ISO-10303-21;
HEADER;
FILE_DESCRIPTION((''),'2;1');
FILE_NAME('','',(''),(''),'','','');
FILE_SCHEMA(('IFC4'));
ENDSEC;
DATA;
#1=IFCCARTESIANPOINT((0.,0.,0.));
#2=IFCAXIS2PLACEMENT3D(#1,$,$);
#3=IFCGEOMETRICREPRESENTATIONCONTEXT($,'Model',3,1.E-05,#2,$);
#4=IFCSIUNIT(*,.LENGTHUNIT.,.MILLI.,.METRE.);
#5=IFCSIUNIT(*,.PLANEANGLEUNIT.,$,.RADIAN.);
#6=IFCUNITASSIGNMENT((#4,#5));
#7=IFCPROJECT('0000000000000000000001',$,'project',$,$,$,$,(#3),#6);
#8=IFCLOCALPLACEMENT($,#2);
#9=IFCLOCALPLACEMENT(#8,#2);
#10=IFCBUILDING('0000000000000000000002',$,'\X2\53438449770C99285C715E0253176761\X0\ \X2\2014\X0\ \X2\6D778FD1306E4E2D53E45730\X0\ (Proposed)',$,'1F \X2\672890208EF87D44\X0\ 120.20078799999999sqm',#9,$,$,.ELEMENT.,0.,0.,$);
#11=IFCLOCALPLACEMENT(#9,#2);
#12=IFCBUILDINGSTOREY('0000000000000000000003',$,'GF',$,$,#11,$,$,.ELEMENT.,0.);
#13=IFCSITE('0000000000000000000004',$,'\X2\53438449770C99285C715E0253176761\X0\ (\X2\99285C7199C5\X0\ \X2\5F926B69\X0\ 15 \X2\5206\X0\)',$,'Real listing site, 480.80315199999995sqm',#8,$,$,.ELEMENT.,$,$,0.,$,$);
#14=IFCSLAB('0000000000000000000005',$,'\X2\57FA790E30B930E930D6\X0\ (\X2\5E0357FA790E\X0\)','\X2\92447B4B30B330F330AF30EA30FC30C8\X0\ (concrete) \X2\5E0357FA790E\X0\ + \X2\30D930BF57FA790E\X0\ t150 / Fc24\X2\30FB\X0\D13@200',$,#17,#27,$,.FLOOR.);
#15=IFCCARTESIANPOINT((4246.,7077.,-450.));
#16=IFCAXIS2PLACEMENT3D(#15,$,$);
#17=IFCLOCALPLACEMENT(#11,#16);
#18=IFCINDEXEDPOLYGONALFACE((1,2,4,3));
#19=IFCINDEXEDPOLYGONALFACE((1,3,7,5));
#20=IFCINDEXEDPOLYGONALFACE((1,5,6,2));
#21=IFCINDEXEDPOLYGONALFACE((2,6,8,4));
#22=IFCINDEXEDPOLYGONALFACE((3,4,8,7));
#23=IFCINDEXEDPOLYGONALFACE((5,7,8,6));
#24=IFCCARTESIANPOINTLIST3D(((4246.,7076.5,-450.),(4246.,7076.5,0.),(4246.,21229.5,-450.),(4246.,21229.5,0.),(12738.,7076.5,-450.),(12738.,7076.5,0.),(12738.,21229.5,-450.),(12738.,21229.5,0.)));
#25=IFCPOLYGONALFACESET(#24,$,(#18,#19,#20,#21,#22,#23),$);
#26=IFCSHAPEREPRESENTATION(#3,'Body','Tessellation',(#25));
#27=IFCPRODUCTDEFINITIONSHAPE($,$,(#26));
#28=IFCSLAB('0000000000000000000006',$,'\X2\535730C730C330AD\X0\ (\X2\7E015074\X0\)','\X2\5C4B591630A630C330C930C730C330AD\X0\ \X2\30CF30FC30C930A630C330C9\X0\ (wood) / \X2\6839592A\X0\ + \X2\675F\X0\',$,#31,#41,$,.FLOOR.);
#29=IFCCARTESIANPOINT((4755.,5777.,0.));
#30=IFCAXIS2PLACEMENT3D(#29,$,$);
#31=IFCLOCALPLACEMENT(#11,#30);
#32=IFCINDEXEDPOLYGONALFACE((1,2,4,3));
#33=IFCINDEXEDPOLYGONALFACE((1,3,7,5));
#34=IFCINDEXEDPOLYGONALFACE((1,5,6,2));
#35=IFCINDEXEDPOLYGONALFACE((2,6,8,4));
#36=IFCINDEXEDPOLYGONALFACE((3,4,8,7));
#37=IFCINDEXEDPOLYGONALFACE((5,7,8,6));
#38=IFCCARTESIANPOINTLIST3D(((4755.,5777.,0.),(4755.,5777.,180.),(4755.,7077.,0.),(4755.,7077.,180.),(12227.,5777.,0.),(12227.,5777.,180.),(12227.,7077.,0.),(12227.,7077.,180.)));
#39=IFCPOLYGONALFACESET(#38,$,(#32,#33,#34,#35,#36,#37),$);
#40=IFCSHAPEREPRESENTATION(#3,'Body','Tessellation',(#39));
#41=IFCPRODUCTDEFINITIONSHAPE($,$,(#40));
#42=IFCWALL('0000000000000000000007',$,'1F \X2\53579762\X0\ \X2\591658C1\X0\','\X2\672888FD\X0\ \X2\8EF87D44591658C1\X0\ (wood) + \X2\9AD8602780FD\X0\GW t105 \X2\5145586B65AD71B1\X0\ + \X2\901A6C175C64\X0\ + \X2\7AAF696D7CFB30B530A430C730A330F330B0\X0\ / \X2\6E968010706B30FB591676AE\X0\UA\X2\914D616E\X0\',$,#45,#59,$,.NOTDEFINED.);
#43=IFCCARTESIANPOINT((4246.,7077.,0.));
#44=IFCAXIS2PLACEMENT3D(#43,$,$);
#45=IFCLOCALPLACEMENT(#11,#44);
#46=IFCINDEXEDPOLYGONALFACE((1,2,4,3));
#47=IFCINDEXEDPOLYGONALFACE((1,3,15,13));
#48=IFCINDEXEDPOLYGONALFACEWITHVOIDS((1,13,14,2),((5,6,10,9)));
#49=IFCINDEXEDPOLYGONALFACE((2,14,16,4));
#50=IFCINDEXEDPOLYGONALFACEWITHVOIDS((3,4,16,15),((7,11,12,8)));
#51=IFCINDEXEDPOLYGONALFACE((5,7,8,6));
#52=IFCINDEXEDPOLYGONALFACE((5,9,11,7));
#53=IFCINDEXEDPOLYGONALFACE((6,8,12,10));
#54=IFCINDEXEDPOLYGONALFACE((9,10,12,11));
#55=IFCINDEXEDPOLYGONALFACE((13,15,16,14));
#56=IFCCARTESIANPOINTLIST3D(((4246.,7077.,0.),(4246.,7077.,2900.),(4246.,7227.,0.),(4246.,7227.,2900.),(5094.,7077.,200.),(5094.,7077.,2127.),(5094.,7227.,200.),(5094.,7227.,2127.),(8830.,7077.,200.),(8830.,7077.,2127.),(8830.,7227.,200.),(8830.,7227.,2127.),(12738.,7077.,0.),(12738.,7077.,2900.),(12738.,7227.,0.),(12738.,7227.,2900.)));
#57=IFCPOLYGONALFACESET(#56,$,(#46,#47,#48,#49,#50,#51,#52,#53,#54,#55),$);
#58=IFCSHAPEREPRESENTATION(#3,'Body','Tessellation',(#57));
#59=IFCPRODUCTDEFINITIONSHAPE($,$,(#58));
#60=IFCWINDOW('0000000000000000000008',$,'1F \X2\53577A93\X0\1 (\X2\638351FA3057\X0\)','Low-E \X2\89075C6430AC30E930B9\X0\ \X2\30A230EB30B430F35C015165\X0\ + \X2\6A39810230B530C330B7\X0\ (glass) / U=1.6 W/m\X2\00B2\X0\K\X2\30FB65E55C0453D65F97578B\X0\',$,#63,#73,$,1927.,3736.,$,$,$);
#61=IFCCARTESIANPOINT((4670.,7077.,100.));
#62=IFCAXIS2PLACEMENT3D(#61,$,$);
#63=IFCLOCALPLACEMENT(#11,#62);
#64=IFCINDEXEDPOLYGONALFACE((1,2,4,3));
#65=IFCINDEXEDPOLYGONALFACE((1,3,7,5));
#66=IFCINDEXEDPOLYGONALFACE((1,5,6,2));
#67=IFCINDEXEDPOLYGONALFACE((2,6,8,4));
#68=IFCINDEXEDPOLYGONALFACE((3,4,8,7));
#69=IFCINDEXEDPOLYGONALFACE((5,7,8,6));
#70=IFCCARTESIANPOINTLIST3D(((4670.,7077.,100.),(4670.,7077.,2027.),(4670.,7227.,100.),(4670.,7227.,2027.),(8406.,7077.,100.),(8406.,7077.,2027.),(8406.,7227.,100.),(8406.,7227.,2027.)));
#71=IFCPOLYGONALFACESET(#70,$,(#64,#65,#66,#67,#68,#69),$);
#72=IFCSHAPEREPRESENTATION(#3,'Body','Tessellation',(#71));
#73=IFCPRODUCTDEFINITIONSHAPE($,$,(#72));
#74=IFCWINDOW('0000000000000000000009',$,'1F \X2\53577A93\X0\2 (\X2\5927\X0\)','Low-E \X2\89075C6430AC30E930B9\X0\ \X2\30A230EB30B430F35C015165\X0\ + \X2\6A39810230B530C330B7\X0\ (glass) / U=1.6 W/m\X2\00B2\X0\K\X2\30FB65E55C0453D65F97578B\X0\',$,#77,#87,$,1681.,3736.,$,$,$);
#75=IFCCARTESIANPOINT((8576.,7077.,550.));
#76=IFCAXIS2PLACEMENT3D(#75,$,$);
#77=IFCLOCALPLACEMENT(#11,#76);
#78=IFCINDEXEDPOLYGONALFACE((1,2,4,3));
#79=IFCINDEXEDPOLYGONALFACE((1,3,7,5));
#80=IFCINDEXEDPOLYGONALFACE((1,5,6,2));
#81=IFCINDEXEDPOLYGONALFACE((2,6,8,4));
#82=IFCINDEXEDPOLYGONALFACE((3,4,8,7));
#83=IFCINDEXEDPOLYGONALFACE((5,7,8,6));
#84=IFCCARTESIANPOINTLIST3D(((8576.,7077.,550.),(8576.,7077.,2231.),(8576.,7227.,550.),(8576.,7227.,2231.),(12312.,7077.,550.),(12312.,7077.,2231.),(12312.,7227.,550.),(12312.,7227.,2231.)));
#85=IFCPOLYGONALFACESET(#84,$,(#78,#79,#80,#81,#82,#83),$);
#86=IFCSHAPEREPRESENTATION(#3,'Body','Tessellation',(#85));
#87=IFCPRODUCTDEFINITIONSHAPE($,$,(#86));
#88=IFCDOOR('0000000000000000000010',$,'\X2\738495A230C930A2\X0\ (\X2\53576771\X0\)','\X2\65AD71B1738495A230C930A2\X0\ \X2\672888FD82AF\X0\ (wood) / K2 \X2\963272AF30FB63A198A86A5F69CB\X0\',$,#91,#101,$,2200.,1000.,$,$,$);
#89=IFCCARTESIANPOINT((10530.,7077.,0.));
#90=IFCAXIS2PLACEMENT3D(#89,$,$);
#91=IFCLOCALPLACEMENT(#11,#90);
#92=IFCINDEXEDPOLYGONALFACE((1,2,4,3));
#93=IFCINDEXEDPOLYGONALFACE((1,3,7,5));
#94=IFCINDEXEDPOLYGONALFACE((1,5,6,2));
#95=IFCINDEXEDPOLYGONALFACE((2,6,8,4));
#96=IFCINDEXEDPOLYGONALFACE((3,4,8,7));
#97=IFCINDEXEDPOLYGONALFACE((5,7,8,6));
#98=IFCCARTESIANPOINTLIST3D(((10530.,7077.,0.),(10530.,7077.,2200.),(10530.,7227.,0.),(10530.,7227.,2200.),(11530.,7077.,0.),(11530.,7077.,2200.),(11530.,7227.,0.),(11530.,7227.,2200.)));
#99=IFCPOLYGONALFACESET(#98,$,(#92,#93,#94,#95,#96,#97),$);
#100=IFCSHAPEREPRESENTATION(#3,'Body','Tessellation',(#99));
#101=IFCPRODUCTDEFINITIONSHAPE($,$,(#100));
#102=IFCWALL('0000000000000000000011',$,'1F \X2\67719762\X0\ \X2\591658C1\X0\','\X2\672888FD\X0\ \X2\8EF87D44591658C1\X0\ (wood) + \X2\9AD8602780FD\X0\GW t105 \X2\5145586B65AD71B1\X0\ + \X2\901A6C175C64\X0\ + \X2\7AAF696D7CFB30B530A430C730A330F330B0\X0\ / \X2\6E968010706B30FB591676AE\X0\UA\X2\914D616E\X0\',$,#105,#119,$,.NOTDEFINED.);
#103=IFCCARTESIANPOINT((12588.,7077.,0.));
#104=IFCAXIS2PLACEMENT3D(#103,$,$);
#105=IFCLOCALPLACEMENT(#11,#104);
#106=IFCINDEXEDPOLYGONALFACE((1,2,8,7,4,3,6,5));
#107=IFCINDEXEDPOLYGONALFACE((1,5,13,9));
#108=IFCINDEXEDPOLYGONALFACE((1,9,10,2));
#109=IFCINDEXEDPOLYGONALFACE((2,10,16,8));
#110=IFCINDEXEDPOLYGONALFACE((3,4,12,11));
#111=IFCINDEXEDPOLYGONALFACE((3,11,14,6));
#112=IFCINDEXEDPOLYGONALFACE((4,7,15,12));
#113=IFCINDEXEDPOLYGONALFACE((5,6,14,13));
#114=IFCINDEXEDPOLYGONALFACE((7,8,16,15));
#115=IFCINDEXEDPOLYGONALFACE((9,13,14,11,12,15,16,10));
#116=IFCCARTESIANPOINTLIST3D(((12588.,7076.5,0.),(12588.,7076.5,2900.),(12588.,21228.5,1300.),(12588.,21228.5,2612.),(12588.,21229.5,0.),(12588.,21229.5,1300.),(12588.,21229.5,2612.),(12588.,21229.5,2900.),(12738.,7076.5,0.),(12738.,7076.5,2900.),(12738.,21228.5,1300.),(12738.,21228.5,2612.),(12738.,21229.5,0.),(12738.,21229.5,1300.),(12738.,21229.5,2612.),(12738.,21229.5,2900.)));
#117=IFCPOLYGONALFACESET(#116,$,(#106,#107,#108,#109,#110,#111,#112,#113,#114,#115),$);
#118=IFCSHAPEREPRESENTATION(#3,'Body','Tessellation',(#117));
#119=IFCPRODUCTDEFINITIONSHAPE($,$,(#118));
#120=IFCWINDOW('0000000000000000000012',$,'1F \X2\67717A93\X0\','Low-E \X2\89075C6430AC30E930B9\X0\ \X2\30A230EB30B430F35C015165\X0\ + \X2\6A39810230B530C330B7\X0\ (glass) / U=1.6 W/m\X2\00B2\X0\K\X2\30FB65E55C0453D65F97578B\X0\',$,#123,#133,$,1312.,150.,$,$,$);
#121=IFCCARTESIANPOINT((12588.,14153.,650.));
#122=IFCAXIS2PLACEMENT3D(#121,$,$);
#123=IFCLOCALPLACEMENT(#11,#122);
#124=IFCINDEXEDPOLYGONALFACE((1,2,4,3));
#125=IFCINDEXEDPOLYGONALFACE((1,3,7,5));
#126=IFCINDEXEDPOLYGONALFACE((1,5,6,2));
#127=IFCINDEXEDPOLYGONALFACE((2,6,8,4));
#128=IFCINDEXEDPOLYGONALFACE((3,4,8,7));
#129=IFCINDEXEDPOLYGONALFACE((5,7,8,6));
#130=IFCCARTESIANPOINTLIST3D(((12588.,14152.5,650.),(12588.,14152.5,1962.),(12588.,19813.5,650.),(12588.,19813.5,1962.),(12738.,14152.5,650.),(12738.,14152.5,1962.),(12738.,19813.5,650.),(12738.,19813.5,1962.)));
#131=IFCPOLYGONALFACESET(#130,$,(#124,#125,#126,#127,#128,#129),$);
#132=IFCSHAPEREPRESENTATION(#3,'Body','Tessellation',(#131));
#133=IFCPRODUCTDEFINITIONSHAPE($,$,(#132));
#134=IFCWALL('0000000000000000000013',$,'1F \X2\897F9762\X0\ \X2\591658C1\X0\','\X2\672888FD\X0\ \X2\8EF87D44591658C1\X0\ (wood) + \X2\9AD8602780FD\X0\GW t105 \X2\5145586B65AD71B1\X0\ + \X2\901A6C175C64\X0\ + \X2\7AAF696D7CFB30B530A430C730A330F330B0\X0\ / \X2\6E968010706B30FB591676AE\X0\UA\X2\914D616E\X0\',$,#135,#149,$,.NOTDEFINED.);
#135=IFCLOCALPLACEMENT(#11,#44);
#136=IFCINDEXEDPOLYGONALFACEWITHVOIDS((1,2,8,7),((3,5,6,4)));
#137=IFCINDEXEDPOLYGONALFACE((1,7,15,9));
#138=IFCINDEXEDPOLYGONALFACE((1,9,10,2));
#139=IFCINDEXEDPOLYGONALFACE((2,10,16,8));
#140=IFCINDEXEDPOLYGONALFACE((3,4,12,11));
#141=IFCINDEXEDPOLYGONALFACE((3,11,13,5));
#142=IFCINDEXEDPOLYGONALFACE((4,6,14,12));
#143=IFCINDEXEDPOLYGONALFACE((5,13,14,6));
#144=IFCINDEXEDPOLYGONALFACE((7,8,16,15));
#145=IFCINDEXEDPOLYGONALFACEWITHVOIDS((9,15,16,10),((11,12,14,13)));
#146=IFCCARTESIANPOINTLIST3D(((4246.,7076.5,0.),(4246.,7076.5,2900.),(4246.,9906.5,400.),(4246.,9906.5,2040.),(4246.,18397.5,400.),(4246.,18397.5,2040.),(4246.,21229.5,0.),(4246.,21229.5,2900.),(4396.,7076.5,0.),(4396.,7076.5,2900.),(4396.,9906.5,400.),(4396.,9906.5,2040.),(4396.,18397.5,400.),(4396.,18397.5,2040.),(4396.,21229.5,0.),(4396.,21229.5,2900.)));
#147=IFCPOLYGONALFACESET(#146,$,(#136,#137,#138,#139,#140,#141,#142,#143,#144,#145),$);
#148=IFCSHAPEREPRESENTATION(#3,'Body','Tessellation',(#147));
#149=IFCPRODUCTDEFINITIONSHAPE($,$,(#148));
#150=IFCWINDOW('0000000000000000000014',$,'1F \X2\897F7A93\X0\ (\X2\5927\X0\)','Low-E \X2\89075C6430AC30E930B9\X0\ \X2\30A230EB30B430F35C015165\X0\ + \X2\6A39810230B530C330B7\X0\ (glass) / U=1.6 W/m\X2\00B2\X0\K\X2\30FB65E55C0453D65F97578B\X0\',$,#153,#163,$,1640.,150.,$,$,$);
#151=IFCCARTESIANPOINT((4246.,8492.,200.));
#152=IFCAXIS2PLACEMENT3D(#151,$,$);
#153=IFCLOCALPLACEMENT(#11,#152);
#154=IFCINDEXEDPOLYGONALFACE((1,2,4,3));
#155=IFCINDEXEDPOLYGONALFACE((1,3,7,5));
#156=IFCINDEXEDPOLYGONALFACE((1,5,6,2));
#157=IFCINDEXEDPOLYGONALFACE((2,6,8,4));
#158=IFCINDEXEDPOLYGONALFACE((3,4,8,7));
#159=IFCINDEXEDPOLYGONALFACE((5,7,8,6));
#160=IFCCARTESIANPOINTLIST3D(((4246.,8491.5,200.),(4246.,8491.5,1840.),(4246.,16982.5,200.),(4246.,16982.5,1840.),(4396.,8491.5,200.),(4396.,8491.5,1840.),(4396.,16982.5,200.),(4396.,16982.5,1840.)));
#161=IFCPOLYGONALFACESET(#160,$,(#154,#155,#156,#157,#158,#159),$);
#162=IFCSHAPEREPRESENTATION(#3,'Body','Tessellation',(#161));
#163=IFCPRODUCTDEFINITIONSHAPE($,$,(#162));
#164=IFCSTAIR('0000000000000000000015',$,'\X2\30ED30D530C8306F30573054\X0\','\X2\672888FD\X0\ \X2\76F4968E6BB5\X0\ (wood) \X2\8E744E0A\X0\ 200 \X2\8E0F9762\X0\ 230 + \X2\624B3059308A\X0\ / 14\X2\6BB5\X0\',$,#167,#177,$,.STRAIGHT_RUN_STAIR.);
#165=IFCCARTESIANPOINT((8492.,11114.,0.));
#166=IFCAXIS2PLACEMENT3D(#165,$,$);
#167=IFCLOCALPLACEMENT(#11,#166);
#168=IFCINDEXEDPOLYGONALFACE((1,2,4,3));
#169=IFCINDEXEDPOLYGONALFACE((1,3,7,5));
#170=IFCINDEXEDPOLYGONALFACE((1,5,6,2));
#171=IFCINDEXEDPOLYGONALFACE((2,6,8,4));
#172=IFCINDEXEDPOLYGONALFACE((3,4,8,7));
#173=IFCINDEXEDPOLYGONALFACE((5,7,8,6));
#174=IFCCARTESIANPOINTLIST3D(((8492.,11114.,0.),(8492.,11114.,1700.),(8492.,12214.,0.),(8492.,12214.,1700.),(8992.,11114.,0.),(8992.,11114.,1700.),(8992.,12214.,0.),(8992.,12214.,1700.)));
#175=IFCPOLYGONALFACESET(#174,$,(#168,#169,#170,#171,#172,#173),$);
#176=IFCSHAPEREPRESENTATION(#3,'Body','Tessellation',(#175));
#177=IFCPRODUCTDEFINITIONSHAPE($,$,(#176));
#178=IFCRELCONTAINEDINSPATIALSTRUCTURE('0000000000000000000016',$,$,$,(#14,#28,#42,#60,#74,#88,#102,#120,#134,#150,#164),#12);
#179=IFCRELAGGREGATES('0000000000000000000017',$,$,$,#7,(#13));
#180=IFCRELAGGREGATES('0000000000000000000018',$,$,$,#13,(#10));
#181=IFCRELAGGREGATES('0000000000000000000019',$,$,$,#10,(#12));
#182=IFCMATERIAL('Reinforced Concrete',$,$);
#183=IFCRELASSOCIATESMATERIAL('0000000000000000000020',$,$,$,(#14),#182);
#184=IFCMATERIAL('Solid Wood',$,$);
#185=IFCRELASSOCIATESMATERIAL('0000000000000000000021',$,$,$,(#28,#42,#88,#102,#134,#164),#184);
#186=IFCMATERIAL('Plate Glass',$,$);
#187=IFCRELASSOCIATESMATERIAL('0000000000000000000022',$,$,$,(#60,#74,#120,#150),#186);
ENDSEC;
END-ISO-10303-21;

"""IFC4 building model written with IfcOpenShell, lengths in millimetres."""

from ifc_helpers import new_model, si_unit, frame, frame_2d, origin, place, context, project, spatial, rectangle, extrude, material, element, fill, save


model = new_model("IFC4")

# Units and contexts
model_context = context("Model", 3, precision=1e-05, world=origin())
ifc_project = project(units=[si_unit("LENGTHUNIT", "METRE", prefix="MILLI"), si_unit("PLANEANGLEUNIT", "RADIAN")], contexts=[model_context])

# Site, building, storey
site_placement = place(None, origin())
site = spatial("IfcSite", under=ifc_project, at=site_placement, Name="千葉県館山市北条 (館山駅 徒歩 15 分)", ObjectType="Real listing site, 480.80315199999995sqm", CompositionType="ELEMENT", RefElevation=0.0)
building_placement = place(site_placement, origin())
building = spatial("IfcBuilding", under=site, at=building_placement, Name="千葉県館山市北条 — 海近の中古地 (Proposed)", ObjectType="1F 木造軸組 120.20078799999999sqm", CompositionType="ELEMENT", ElevationOfRefHeight=0.0, ElevationOfTerrain=0.0)
storey_placement = place(building_placement, origin())
storey = spatial("IfcBuildingStorey", under=building, at=storey_placement, Name="GF", CompositionType="ELEMENT", Elevation=0.0)

# Slabs
ifc_material_1 = material(Name="Reinforced Concrete")
slab_1_placement = place(storey_placement, frame((4246.0, 7077.0, -450.0)))
element("IfcSlab", 1, at=slab_1_placement, inside=storey, material=ifc_material_1, Name="基礎スラブ (布基礎)", Description="鉄筋コンクリート (concrete) 布基礎 + ベタ基礎 t150 / Fc24・D13@200", PredefinedType="FLOOR", context=model_context, shape_type="SweptSolid", body=[
    extrude(rectangle(XDim=8492.0, YDim=14153.0, at=frame_2d((4246.0, 7076.0))), frame((4246.0, 7077.0, -450.0)), (0.0, 0.0, 1.0), 450.0),
])
ifc_material_2 = material(Name="Solid Wood")
slab_2_placement = place(storey_placement, frame((4755.0, 5777.0, 0.0)))
element("IfcSlab", 2, at=slab_2_placement, inside=storey, material=ifc_material_2, Name="南デッキ (縁側)", Description="屋外ウッドデッキ ハードウッド (wood) / 根太 + 束", PredefinedType="FLOOR", context=model_context, shape_type="SweptSolid", body=[
    extrude(rectangle(XDim=7472.0, YDim=1300.0, at=frame_2d((3736.0, 650.0))), frame((4755.0, 5777.0, 0.0)), (0.0, 0.0, 1.0), 180.0),
])

# Wall, openings, windows, door
wall_1_placement = place(storey_placement, frame((4246.0, 7077.0, 0.0)))
wall_1 = element("IfcWall", 3, at=wall_1_placement, inside=storey, material=ifc_material_2, Name="1F 南面 外壁", Description="木製 軸組外壁 (wood) + 高性能GW t105 充填断熱 + 通気層 + 窯業系サイディング / 準耐火・外皮UA配慮", PredefinedType="NOTDEFINED", context=model_context, shape_type="SweptSolid", body=[
    extrude(rectangle(XDim=8492.0, YDim=150.0, at=frame_2d((4246.0, 75.0))), frame((4246.0, 7077.0, 0.0)), (0.0, 0.0, 1.0), 2900.0),
])
opening_1_placement = place(storey_placement, frame((4670.0, 7077.0, 100.0)))
opening_1 = element("IfcOpeningElement", 4, at=opening_1_placement, cuts=wall_1, PredefinedType="NOTDEFINED", context=model_context, shape_type="SweptSolid", body=[
    extrude(rectangle(XDim=3736.0, YDim=150.0, at=frame_2d((1868.0, 75.0))), frame((4670.0, 7077.0, 100.0)), (0.0, 0.0, 1.0), 1927.0),
])
opening_2_placement = place(storey_placement, frame((8576.0, 7077.0, 550.0)))
opening_2 = element("IfcOpeningElement", 5, at=opening_2_placement, cuts=wall_1, PredefinedType="NOTDEFINED", context=model_context, shape_type="SweptSolid", body=[
    extrude(rectangle(XDim=3736.0, YDim=150.0, at=frame_2d((1868.0, 75.0))), frame((8576.0, 7077.0, 550.0)), (0.0, 0.0, 1.0), 1681.0),
])
opening_3_placement = place(storey_placement, frame((10530.0, 7077.0, 0.0)))
opening_3 = element("IfcOpeningElement", 6, at=opening_3_placement, cuts=wall_1, PredefinedType="NOTDEFINED", context=model_context, shape_type="SweptSolid", body=[
    extrude(rectangle(XDim=1000.0, YDim=150.0, at=frame_2d((500.0, 75.0))), frame((10530.0, 7077.0, 0.0)), (0.0, 0.0, 1.0), 2200.0),
])
ifc_material_3 = material(Name="Plate Glass")
window_1_placement = place(storey_placement, frame((4670.0, 7077.0, 100.0)))
window_1 = element("IfcWindow", 7, at=window_1_placement, inside=storey, material=ifc_material_3, Name="1F 南窓1 (掃出し)", Description="Low-E 複層ガラス アルゴン封入 + 樹脂サッシ (glass) / U=1.6 W/m²K・日射取得型", OverallHeight=1927.0, OverallWidth=3736.0, context=model_context, shape_type="SweptSolid", body=[
    extrude(rectangle(XDim=3736.0, YDim=150.0, at=frame_2d((1868.0, 75.0))), frame((4670.0, 7077.0, 100.0)), (0.0, 0.0, 1.0), 1927.0),
])
fill(opening_1, window_1)
window_2_placement = place(storey_placement, frame((8576.0, 7077.0, 550.0)))
window_2 = element("IfcWindow", 8, at=window_2_placement, inside=storey, material=ifc_material_3, Name="1F 南窓2 (大)", Description="Low-E 複層ガラス アルゴン封入 + 樹脂サッシ (glass) / U=1.6 W/m²K・日射取得型", OverallHeight=1681.0, OverallWidth=3736.0, context=model_context, shape_type="SweptSolid", body=[
    extrude(rectangle(XDim=3736.0, YDim=150.0, at=frame_2d((1868.0, 75.0))), frame((8576.0, 7077.0, 550.0)), (0.0, 0.0, 1.0), 1681.0),
])
fill(opening_2, window_2)
door_placement = place(storey_placement, frame((10530.0, 7077.0, 0.0)))
door = element("IfcDoor", 9, at=door_placement, inside=storey, material=ifc_material_2, Name="玄関ドア (南東)", Description="断熱玄関ドア 木製芯 (wood) / K2 防犯・採風機構", OverallHeight=2200.0, OverallWidth=1000.0, context=model_context, shape_type="SweptSolid", body=[
    extrude(rectangle(XDim=1000.0, YDim=150.0, at=frame_2d((500.0, 75.0))), frame((10530.0, 7077.0, 0.0)), (0.0, 0.0, 1.0), 2200.0),
])
fill(opening_3, door)

# Walls, openings, windows
wall_2_placement = place(storey_placement, frame((12588.0, 7077.0, 0.0)))
wall_2 = element("IfcWall", 10, at=wall_2_placement, inside=storey, material=ifc_material_2, Name="1F 東面 外壁", Description="木製 軸組外壁 (wood) + 高性能GW t105 充填断熱 + 通気層 + 窯業系サイディング / 準耐火・外皮UA配慮", PredefinedType="NOTDEFINED", context=model_context, shape_type="SweptSolid", body=[
    extrude(rectangle(XDim=150.0, YDim=14153.0, at=frame_2d((75.0, 7076.0))), frame((12588.0, 7077.0, 0.0)), (0.0, 0.0, 1.0), 2900.0),
])
opening_4_placement = place(storey_placement, frame((12588.0, 14153.0, 650.0)))
opening_4 = element("IfcOpeningElement", 11, at=opening_4_placement, cuts=wall_2, PredefinedType="NOTDEFINED", context=model_context, shape_type="SweptSolid", body=[
    extrude(rectangle(XDim=150.0, YDim=5661.0, at=frame_2d((75.0, 2830.0))), frame((12588.0, 14153.0, 650.0)), (0.0, 0.0, 1.0), 1312.0),
])
window_3_placement = place(storey_placement, frame((12588.0, 14153.0, 650.0)))
window_3 = element("IfcWindow", 12, at=window_3_placement, inside=storey, material=ifc_material_3, Name="1F 東窓", Description="Low-E 複層ガラス アルゴン封入 + 樹脂サッシ (glass) / U=1.6 W/m²K・日射取得型", OverallHeight=1312.0, OverallWidth=150.0, context=model_context, shape_type="SweptSolid", body=[
    extrude(rectangle(XDim=150.0, YDim=5661.0, at=frame_2d((75.0, 2830.0))), frame((12588.0, 14153.0, 650.0)), (0.0, 0.0, 1.0), 1312.0),
])
fill(opening_4, window_3)
wall_3_placement = place(storey_placement, frame((4246.0, 7077.0, 0.0)))
wall_3 = element("IfcWall", 13, at=wall_3_placement, inside=storey, material=ifc_material_2, Name="1F 西面 外壁", Description="木製 軸組外壁 (wood) + 高性能GW t105 充填断熱 + 通気層 + 窯業系サイディング / 準耐火・外皮UA配慮", PredefinedType="NOTDEFINED", context=model_context, shape_type="SweptSolid", body=[
    extrude(rectangle(XDim=150.0, YDim=14153.0, at=frame_2d((75.0, 7076.0))), frame((4246.0, 7077.0, 0.0)), (0.0, 0.0, 1.0), 2900.0),
])
opening_5_placement = place(storey_placement, frame((4246.0, 8492.0, 200.0)))
opening_5 = element("IfcOpeningElement", 14, at=opening_5_placement, cuts=wall_3, PredefinedType="NOTDEFINED", context=model_context, shape_type="SweptSolid", body=[
    extrude(rectangle(XDim=150.0, YDim=8491.0, at=frame_2d((75.0, 4245.0))), frame((4246.0, 8492.0, 200.0)), (0.0, 0.0, 1.0), 1640.0),
])
window_4_placement = place(storey_placement, frame((4246.0, 8492.0, 200.0)))
window_4 = element("IfcWindow", 15, at=window_4_placement, inside=storey, material=ifc_material_3, Name="1F 西窓 (大)", Description="Low-E 複層ガラス アルゴン封入 + 樹脂サッシ (glass) / U=1.6 W/m²K・日射取得型", OverallHeight=1640.0, OverallWidth=150.0, context=model_context, shape_type="SweptSolid", body=[
    extrude(rectangle(XDim=150.0, YDim=8491.0, at=frame_2d((75.0, 4245.0))), frame((4246.0, 8492.0, 200.0)), (0.0, 0.0, 1.0), 1640.0),
])
fill(opening_5, window_4)

# Stair
stair_placement = place(storey_placement, frame((8492.0, 11114.0, 0.0)))
element("IfcStair", 16, at=stair_placement, inside=storey, material=ifc_material_2, Name="ロフトはしご", Description="木製 直階段 (wood) 蹴上 200 踏面 230 + 手すり / 14段", PredefinedType="STRAIGHT_RUN_STAIR", context=model_context, shape_type="SweptSolid", body=[
    extrude(rectangle(XDim=500.0, YDim=1100.0, at=frame_2d((250.0, 550.0))), frame((8492.0, 11114.0, 0.0)), (0.0, 0.0, 1.0), 1700.0),
])

save(model, "model.ifc")
